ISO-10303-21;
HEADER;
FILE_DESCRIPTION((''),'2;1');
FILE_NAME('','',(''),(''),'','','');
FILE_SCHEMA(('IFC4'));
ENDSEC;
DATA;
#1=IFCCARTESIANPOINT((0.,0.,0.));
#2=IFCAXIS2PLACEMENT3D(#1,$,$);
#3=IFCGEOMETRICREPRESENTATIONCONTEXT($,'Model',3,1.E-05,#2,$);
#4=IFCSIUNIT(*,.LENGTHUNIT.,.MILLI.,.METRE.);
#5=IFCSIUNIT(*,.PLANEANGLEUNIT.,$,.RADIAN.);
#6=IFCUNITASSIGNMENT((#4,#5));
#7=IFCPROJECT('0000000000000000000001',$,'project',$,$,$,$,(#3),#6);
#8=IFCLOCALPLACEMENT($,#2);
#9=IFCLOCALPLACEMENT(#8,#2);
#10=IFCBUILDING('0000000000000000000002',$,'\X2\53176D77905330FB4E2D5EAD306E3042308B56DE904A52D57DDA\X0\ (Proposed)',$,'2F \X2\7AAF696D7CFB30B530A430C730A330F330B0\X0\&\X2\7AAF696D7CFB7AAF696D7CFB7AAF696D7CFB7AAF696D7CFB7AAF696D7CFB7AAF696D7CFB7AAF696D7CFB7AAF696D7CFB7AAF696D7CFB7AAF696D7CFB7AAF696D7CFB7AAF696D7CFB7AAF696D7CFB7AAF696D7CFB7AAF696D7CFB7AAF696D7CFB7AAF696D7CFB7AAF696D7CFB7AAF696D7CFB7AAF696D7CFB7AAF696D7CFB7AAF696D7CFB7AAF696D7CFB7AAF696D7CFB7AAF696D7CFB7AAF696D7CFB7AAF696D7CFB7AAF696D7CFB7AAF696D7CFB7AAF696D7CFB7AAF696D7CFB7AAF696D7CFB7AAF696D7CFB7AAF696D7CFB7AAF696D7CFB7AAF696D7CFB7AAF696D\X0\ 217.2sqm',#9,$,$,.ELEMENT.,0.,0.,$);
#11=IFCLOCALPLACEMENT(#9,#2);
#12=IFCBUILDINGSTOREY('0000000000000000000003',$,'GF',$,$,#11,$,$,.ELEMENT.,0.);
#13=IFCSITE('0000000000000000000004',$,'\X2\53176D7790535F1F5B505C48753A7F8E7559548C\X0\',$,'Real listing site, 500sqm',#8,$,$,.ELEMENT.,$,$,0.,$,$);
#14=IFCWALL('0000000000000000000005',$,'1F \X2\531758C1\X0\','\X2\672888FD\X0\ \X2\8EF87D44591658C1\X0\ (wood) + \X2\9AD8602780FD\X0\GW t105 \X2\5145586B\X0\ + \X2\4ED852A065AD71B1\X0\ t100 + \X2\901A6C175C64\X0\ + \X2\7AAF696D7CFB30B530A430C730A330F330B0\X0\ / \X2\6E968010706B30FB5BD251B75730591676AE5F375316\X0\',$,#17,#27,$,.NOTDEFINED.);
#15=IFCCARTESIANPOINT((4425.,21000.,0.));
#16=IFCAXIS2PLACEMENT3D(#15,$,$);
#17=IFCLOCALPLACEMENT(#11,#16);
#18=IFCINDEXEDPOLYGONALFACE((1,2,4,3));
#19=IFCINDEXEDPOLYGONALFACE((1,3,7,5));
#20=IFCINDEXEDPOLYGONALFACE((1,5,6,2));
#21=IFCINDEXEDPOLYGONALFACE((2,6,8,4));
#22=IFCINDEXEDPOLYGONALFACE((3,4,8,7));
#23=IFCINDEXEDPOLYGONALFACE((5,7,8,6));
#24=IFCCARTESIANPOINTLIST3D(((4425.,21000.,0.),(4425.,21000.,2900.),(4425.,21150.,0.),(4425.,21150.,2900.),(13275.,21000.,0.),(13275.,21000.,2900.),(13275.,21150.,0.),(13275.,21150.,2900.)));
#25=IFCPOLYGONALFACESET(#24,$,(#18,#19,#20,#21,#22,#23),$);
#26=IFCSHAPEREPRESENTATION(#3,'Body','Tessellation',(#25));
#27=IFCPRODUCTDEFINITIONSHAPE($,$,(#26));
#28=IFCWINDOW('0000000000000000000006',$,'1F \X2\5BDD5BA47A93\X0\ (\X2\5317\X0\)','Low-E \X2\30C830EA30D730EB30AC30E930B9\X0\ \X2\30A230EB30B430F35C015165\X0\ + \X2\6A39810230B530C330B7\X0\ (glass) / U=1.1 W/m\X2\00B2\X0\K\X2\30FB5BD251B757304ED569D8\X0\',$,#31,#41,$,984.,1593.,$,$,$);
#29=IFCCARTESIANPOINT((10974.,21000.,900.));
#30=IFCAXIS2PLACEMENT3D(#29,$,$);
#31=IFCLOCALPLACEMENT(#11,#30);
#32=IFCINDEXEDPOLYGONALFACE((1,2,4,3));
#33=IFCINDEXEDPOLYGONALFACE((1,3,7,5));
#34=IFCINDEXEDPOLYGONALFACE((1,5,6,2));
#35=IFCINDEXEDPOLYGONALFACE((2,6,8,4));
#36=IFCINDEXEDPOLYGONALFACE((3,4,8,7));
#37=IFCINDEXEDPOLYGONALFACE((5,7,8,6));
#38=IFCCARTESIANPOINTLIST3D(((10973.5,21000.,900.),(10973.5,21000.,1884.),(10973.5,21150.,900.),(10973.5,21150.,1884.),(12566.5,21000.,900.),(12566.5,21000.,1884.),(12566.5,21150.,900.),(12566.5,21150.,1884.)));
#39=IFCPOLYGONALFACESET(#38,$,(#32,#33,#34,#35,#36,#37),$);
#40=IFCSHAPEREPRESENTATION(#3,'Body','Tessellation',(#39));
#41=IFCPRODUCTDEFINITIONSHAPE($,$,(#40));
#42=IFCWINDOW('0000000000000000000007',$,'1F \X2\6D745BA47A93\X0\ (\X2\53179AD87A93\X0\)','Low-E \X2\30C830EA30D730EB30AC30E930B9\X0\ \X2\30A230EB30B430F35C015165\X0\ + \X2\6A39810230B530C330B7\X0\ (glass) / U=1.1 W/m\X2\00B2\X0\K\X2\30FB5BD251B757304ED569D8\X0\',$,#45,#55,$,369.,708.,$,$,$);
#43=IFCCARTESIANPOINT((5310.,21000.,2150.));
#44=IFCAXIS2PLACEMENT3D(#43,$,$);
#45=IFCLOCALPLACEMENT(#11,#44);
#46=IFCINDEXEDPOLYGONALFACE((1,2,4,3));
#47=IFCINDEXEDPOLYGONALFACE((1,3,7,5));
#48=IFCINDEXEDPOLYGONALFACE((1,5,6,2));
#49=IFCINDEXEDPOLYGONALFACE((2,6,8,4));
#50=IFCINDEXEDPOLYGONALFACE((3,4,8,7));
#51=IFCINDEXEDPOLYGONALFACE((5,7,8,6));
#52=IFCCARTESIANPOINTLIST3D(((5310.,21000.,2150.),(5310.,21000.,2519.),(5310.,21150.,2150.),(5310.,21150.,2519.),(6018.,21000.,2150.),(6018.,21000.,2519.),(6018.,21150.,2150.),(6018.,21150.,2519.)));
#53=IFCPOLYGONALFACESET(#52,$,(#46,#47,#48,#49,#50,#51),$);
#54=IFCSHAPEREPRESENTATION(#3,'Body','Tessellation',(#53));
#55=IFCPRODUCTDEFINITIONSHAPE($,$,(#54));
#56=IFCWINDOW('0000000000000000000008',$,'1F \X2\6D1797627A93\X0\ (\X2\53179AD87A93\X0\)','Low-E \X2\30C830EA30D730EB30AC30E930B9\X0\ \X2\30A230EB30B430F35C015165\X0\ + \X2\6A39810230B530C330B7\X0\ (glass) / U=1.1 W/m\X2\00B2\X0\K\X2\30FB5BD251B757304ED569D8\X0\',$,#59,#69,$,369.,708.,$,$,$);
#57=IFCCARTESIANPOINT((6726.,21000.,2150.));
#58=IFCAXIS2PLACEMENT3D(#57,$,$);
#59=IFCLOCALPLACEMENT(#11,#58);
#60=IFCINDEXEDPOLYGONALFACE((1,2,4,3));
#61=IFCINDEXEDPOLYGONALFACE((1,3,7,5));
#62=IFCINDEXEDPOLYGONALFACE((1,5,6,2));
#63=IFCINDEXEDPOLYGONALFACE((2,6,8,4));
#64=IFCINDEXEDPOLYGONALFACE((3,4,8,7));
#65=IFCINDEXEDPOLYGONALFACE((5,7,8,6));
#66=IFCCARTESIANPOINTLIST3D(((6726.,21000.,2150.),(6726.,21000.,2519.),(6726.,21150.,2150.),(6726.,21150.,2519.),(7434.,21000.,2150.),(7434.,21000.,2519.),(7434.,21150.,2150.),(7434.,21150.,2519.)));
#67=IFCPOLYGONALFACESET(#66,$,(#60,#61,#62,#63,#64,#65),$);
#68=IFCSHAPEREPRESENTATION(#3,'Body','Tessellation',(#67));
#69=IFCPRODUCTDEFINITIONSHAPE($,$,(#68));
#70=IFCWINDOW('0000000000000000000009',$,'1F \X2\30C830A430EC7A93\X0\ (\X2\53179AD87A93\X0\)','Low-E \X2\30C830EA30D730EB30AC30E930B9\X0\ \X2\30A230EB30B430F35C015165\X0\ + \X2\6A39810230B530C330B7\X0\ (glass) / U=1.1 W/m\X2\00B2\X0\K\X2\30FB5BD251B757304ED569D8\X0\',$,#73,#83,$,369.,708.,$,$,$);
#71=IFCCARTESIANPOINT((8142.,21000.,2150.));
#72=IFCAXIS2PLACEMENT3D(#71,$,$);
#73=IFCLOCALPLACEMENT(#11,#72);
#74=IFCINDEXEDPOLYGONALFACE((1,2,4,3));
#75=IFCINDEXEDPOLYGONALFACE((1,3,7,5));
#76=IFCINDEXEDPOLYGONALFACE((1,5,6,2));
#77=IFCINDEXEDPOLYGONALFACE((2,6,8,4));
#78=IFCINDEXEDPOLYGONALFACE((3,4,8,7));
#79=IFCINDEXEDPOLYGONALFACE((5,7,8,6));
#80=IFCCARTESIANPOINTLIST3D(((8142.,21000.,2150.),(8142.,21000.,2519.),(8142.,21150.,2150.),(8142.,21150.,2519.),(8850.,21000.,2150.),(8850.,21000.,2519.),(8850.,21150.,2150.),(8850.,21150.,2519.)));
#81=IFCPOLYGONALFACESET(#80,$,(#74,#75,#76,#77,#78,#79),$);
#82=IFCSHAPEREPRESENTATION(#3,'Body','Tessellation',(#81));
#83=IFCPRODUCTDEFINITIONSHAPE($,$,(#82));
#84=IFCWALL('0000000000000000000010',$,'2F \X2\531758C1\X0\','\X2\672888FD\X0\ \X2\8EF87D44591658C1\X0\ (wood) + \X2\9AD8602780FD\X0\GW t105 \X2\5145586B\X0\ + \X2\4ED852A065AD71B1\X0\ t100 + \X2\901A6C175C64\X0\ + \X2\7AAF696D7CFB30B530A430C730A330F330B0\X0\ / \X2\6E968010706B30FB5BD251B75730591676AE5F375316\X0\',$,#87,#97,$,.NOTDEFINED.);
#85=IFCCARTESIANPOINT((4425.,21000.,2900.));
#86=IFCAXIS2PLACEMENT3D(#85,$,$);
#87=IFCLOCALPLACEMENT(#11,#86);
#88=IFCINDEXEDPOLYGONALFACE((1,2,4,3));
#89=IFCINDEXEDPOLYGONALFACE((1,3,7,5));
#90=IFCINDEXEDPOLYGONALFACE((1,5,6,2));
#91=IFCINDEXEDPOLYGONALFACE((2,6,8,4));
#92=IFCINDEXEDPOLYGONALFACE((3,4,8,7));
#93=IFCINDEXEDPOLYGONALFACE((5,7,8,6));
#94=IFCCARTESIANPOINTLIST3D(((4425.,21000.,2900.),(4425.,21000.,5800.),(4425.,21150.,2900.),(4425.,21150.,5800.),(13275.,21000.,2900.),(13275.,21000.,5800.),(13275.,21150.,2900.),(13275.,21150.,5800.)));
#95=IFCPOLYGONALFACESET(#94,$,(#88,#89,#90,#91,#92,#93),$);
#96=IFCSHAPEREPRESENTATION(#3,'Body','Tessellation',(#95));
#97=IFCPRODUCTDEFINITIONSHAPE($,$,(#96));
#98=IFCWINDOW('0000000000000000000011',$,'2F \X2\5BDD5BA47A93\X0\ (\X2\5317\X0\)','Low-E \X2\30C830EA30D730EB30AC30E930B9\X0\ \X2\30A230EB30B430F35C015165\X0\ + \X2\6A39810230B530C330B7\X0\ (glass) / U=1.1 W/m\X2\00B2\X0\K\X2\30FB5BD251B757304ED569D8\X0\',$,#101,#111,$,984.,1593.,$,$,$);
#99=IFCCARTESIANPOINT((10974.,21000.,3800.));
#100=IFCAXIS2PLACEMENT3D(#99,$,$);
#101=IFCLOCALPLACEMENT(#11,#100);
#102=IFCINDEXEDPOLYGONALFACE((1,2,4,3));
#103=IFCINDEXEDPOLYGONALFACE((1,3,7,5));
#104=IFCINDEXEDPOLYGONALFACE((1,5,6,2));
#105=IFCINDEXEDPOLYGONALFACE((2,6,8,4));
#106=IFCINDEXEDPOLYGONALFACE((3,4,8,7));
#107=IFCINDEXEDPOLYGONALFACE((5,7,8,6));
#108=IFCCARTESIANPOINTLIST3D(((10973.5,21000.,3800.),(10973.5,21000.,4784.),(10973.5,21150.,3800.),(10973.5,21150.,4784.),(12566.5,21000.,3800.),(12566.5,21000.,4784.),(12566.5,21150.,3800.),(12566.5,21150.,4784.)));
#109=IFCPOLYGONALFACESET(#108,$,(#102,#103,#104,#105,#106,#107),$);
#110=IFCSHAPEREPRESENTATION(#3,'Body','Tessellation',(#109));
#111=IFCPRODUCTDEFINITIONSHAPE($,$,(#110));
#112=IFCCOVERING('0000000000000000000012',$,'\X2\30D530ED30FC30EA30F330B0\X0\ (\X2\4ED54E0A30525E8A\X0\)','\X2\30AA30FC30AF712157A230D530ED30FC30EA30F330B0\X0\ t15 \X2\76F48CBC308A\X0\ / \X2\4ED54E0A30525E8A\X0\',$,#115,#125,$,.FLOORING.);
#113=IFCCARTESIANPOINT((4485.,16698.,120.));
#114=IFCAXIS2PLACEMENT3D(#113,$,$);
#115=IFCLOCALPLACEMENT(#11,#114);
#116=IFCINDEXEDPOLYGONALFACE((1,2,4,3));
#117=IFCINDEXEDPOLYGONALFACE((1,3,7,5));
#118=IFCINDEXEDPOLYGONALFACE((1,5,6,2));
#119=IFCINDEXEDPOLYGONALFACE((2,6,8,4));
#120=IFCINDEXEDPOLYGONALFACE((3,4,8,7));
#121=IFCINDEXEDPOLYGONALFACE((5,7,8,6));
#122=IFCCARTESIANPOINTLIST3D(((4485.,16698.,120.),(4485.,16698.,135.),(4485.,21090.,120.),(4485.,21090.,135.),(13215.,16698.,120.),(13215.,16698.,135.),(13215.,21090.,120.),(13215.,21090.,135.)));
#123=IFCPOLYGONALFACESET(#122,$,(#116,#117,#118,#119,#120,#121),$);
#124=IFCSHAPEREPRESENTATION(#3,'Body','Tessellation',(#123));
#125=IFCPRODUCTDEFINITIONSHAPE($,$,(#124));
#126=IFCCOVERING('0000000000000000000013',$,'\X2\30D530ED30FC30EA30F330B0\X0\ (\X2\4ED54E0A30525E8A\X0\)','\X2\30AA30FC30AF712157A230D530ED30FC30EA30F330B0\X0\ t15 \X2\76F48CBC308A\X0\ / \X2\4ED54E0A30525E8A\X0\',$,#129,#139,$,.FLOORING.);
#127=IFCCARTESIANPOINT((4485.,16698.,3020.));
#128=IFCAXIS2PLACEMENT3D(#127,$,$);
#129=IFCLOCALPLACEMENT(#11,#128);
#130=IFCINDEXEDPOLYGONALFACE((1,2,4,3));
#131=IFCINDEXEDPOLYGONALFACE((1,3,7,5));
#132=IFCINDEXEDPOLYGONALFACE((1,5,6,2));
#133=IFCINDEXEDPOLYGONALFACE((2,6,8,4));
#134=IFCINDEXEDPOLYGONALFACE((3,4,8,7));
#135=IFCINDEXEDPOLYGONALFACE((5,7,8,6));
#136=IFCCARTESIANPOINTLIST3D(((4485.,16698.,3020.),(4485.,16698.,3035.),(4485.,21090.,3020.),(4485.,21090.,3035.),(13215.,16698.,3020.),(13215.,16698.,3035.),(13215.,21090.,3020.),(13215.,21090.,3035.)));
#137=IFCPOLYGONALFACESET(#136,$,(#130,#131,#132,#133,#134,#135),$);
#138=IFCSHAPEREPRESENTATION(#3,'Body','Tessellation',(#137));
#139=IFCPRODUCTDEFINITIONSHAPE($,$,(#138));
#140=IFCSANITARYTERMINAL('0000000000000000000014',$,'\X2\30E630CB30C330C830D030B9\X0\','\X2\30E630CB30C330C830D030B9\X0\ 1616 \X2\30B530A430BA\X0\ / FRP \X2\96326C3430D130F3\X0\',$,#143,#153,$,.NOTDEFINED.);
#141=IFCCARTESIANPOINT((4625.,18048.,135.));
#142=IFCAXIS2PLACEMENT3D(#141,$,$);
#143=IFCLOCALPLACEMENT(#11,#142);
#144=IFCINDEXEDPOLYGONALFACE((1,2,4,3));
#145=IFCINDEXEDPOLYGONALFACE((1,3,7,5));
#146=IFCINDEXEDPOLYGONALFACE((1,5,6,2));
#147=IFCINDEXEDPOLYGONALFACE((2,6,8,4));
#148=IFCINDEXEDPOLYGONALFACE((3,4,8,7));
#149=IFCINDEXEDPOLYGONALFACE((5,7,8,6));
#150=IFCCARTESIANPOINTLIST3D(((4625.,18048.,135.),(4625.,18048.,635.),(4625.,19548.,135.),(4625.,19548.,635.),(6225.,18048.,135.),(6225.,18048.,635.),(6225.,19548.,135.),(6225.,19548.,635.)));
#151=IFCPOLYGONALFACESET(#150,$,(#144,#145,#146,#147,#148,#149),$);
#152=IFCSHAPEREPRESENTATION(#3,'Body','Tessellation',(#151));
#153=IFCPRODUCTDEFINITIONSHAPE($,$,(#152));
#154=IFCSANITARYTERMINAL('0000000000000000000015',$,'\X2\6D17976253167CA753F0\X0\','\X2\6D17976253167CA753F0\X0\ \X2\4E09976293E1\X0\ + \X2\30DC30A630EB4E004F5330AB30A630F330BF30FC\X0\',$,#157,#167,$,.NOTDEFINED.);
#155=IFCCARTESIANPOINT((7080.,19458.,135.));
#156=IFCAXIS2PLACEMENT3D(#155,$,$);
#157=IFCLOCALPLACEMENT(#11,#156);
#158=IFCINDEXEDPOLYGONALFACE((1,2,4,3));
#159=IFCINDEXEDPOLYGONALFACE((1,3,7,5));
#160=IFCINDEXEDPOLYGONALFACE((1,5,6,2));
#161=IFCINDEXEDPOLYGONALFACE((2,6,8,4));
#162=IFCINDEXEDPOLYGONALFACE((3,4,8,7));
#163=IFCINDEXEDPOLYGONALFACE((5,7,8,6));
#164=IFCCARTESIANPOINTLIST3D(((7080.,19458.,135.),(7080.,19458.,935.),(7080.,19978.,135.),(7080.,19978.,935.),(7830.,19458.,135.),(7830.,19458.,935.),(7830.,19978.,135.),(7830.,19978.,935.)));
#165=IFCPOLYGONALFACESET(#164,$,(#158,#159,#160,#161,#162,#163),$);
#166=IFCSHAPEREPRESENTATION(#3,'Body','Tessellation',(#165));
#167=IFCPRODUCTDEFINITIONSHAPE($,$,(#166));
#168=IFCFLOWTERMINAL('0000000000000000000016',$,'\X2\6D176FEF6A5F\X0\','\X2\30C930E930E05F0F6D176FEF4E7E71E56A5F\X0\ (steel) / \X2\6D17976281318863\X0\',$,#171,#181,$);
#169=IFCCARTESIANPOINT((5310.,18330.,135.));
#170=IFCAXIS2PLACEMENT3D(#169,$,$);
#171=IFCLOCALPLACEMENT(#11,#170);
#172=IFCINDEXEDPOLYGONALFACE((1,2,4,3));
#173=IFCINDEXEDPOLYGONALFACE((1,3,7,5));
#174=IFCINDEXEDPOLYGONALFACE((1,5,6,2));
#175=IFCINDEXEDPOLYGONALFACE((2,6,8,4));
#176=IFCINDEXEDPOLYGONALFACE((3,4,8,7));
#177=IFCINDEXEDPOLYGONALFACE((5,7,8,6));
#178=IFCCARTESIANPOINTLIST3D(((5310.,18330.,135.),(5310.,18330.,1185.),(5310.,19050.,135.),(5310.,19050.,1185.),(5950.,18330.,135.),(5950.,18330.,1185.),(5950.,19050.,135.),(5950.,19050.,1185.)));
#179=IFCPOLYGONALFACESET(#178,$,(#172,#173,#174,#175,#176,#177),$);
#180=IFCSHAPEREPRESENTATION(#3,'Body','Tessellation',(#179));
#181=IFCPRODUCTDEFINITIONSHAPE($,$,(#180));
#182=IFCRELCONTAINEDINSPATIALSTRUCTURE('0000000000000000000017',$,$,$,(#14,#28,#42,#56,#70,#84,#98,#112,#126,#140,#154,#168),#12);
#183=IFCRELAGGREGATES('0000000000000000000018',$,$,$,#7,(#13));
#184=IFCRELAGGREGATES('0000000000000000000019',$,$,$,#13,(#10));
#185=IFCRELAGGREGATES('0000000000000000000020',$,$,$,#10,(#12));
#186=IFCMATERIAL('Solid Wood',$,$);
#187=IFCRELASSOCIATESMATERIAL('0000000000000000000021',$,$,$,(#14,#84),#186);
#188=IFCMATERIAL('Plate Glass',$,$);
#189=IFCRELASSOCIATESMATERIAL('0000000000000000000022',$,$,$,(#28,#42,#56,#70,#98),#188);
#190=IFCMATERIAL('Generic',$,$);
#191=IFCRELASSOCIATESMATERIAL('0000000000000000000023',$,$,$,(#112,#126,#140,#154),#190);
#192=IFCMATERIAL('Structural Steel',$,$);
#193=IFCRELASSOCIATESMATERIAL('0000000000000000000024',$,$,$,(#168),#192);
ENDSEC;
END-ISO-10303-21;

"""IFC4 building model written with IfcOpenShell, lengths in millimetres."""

from ifc_helpers import new_model, si_unit, frame, frame_2d, origin, place, context, project, spatial, rectangle, extrude, material, element, fill, save


model = new_model("IFC4")

# Units and contexts
model_context = context("Model", 3, precision=1e-05, world=origin())
ifc_project = project(units=[si_unit("LENGTHUNIT", "METRE", prefix="MILLI"), si_unit("PLANEANGLEUNIT", "RADIAN")], contexts=[model_context])

# Site, building, storey
site_placement = place(None, origin())
site = spatial("IfcSite", under=ifc_project, at=site_placement, Name="北海道弟子屈町美留和", ObjectType="Real listing site, 500sqm", CompositionType="ELEMENT", RefElevation=0.0)
building_placement = place(site_placement, origin())
building = spatial("IfcBuilding", under=site, at=building_placement, Name="北海道・中庭のある回遊動線 (Proposed)", ObjectType="2F 窯業系サイディング&窯業系窯業系窯業系窯業系窯業系窯業系窯業系窯業系窯業系窯業系窯業系窯業系窯業系窯業系窯業系窯業系窯業系窯業系窯業系窯業系窯業系窯業系窯業系窯業系窯業系窯業系窯業系窯業系窯業系窯業系窯業系窯業系窯業系窯業系窯業系窯業系窯業 217.2sqm", CompositionType="ELEMENT", ElevationOfRefHeight=0.0, ElevationOfTerrain=0.0)
storey_placement = place(building_placement, origin())
storey = spatial("IfcBuildingStorey", under=building, at=storey_placement, Name="GF", CompositionType="ELEMENT", Elevation=0.0)

# Shared definitions
ifc_material_1 = material(Name="Solid Wood")

# Wall, openings, windows
wall_1_placement = place(storey_placement, frame((4425.0, 21000.0, 0.0)))
wall_1 = element("IfcWall", 1, at=wall_1_placement, inside=storey, material=ifc_material_1, Name="1F 北壁", Description="木製 軸組外壁 (wood) + 高性能GW t105 充填 + 付加断熱 t100 + 通気層 + 窯業系サイディング / 準耐火・寒冷地外皮強化", PredefinedType="NOTDEFINED", context=model_context, shape_type="SweptSolid", body=[
    extrude(rectangle(XDim=8850.0, YDim=150.0, at=frame_2d((4425.0, 75.0))), frame((4425.0, 21000.0, 0.0)), (0.0, 0.0, 1.0), 2900.0),
])
opening_1_placement = place(storey_placement, frame((10974.0, 21000.0, 900.0)))
opening_1 = element("IfcOpeningElement", 2, at=opening_1_placement, cuts=wall_1, PredefinedType="NOTDEFINED", context=model_context, shape_type="SweptSolid", body=[
    extrude(rectangle(XDim=1593.0, YDim=150.0, at=frame_2d((796.0, 75.0))), frame((10974.0, 21000.0, 900.0)), (0.0, 0.0, 1.0), 984.0),
])
opening_2_placement = place(storey_placement, frame((5310.0, 21000.0, 2150.0)))
opening_2 = element("IfcOpeningElement", 3, at=opening_2_placement, cuts=wall_1, PredefinedType="NOTDEFINED", context=model_context, shape_type="SweptSolid", body=[
    extrude(rectangle(XDim=708.0, YDim=150.0, at=frame_2d((354.0, 75.0))), frame((5310.0, 21000.0, 2150.0)), (0.0, 0.0, 1.0), 369.0),
])
opening_3_placement = place(storey_placement, frame((6726.0, 21000.0, 2150.0)))
opening_3 = element("IfcOpeningElement", 4, at=opening_3_placement, cuts=wall_1, PredefinedType="NOTDEFINED", context=model_context, shape_type="SweptSolid", body=[
    extrude(rectangle(XDim=708.0, YDim=150.0, at=frame_2d((354.0, 75.0))), frame((6726.0, 21000.0, 2150.0)), (0.0, 0.0, 1.0), 369.0),
])
opening_4_placement = place(storey_placement, frame((8142.0, 21000.0, 2150.0)))
opening_4 = element("IfcOpeningElement", 5, at=opening_4_placement, cuts=wall_1, PredefinedType="NOTDEFINED", context=model_context, shape_type="SweptSolid", body=[
    extrude(rectangle(XDim=708.0, YDim=150.0, at=frame_2d((354.0, 75.0))), frame((8142.0, 21000.0, 2150.0)), (0.0, 0.0, 1.0), 369.0),
])
ifc_material_2 = material(Name="Plate Glass")
window_1_placement = place(storey_placement, frame((10974.0, 21000.0, 900.0)))
window_1 = element("IfcWindow", 6, at=window_1_placement, inside=storey, material=ifc_material_2, Name="1F 寝室窓 (北)", Description="Low-E トリプルガラス アルゴン封入 + 樹脂サッシ (glass) / U=1.1 W/m²K・寒冷地仕様", OverallHeight=984.0, OverallWidth=1593.0, context=model_context, shape_type="SweptSolid", body=[
    extrude(rectangle(XDim=1593.0, YDim=150.0, at=frame_2d((796.0, 75.0))), frame((10974.0, 21000.0, 900.0)), (0.0, 0.0, 1.0), 984.0),
])
fill(opening_1, window_1)
window_2_placement = place(storey_placement, frame((5310.0, 21000.0, 2150.0)))
window_2 = element("IfcWindow", 7, at=window_2_placement, inside=storey, material=ifc_material_2, Name="1F 浴室窓 (北高窓)", Description="Low-E トリプルガラス アルゴン封入 + 樹脂サッシ (glass) / U=1.1 W/m²K・寒冷地仕様", OverallHeight=369.0, OverallWidth=708.0, context=model_context, shape_type="SweptSolid", body=[
    extrude(rectangle(XDim=708.0, YDim=150.0, at=frame_2d((354.0, 75.0))), frame((5310.0, 21000.0, 2150.0)), (0.0, 0.0, 1.0), 369.0),
])
fill(opening_2, window_2)
window_3_placement = place(storey_placement, frame((6726.0, 21000.0, 2150.0)))
window_3 = element("IfcWindow", 8, at=window_3_placement, inside=storey, material=ifc_material_2, Name="1F 洗面窓 (北高窓)", Description="Low-E トリプルガラス アルゴン封入 + 樹脂サッシ (glass) / U=1.1 W/m²K・寒冷地仕様", OverallHeight=369.0, OverallWidth=708.0, context=model_context, shape_type="SweptSolid", body=[
    extrude(rectangle(XDim=708.0, YDim=150.0, at=frame_2d((354.0, 75.0))), frame((6726.0, 21000.0, 2150.0)), (0.0, 0.0, 1.0), 369.0),
])
fill(opening_3, window_3)
window_4_placement = place(storey_placement, frame((8142.0, 21000.0, 2150.0)))
window_4 = element("IfcWindow", 9, at=window_4_placement, inside=storey, material=ifc_material_2, Name="1F トイレ窓 (北高窓)", Description="Low-E トリプルガラス アルゴン封入 + 樹脂サッシ (glass) / U=1.1 W/m²K・寒冷地仕様", OverallHeight=369.0, OverallWidth=708.0, context=model_context, shape_type="SweptSolid", body=[
    extrude(rectangle(XDim=708.0, YDim=150.0, at=frame_2d((354.0, 75.0))), frame((8142.0, 21000.0, 2150.0)), (0.0, 0.0, 1.0), 369.0),
])
fill(opening_4, window_4)

# Wall, opening, window
wall_2_placement = place(storey_placement, frame((4425.0, 21000.0, 2900.0)))
wall_2 = element("IfcWall", 10, at=wall_2_placement, inside=storey, material=ifc_material_1, Name="2F 北壁", Description="木製 軸組外壁 (wood) + 高性能GW t105 充填 + 付加断熱 t100 + 通気層 + 窯業系サイディング / 準耐火・寒冷地外皮強化", PredefinedType="NOTDEFINED", context=model_context, shape_type="SweptSolid", body=[
    extrude(rectangle(XDim=8850.0, YDim=150.0, at=frame_2d((4425.0, 75.0))), frame((4425.0, 21000.0, 2900.0)), (0.0, 0.0, 1.0), 2900.0),
])
opening_5_placement = place(storey_placement, frame((10974.0, 21000.0, 3800.0)))
opening_5 = element("IfcOpeningElement", 11, at=opening_5_placement, cuts=wall_2, PredefinedType="NOTDEFINED", context=model_context, shape_type="SweptSolid", body=[
    extrude(rectangle(XDim=1593.0, YDim=150.0, at=frame_2d((796.0, 75.0))), frame((10974.0, 21000.0, 3800.0)), (0.0, 0.0, 1.0), 984.0),
])
window_5_placement = place(storey_placement, frame((10974.0, 21000.0, 3800.0)))
window_5 = element("IfcWindow", 12, at=window_5_placement, inside=storey, material=ifc_material_2, Name="2F 寝室窓 (北)", Description="Low-E トリプルガラス アルゴン封入 + 樹脂サッシ (glass) / U=1.1 W/m²K・寒冷地仕様", OverallHeight=984.0, OverallWidth=1593.0, context=model_context, shape_type="SweptSolid", body=[
    extrude(rectangle(XDim=1593.0, YDim=150.0, at=frame_2d((796.0, 75.0))), frame((10974.0, 21000.0, 3800.0)), (0.0, 0.0, 1.0), 984.0),
])
fill(opening_5, window_5)

# Coverings
ifc_material_3 = material(Name="Generic")
covering_1_placement = place(storey_placement, frame((4485.0, 16698.0, 120.0)))
element("IfcCovering", 13, at=covering_1_placement, inside=storey, material=ifc_material_3, Name="フローリング (仕上げ床)", Description="オーク無垢フローリング t15 直貼り / 仕上げ床", PredefinedType="FLOORING", context=model_context, shape_type="SweptSolid", body=[
    extrude(rectangle(XDim=8730.0, YDim=4392.0, at=frame_2d((4365.0, 2196.0))), frame((4485.0, 16698.0, 120.0)), (0.0, 0.0, 1.0), 15.0),
])
covering_2_placement = place(storey_placement, frame((4485.0, 16698.0, 3020.0)))
element("IfcCovering", 14, at=covering_2_placement, inside=storey, material=ifc_material_3, Name="フローリング (仕上げ床)", Description="オーク無垢フローリング t15 直貼り / 仕上げ床", PredefinedType="FLOORING", context=model_context, shape_type="SweptSolid", body=[
    extrude(rectangle(XDim=8730.0, YDim=4392.0, at=frame_2d((4365.0, 2196.0))), frame((4485.0, 16698.0, 3020.0)), (0.0, 0.0, 1.0), 15.0),
])

# Sanitary terminals
sanitary_terminal_1_placement = place(storey_placement, frame((4625.0, 18048.0, 135.0)))
element("IfcSanitaryTerminal", 15, at=sanitary_terminal_1_placement, inside=storey, material=ifc_material_3, Name="ユニットバス", Description="ユニットバス 1616 サイズ / FRP 防水パン", PredefinedType="NOTDEFINED", context=model_context, shape_type="SweptSolid", body=[
    extrude(rectangle(XDim=1600.0, YDim=1500.0, at=frame_2d((800.0, 750.0))), frame((4625.0, 18048.0, 135.0)), (0.0, 0.0, 1.0), 500.0),
])
sanitary_terminal_2_placement = place(storey_placement, frame((7080.0, 19458.0, 135.0)))
element("IfcSanitaryTerminal", 16, at=sanitary_terminal_2_placement, inside=storey, material=ifc_material_3, Name="洗面化粧台", Description="洗面化粧台 三面鏡 + ボウル一体カウンター", PredefinedType="NOTDEFINED", context=model_context, shape_type="SweptSolid", body=[
    extrude(rectangle(XDim=750.0, YDim=520.0, at=frame_2d((375.0, 260.0))), frame((7080.0, 19458.0, 135.0)), (0.0, 0.0, 1.0), 800.0),
])

# Flow terminal
ifc_material_4 = material(Name="Structural Steel")
flow_terminal_placement = place(storey_placement, frame((5310.0, 18330.0, 135.0)))
element("IfcFlowTerminal", 17, at=flow_terminal_placement, inside=storey, material=ifc_material_4, Name="洗濯機", Description="ドラム式洗濯乾燥機 (steel) / 洗面脱衣", context=model_context, shape_type="SweptSolid", body=[
    extrude(rectangle(XDim=640.0, YDim=720.0, at=frame_2d((320.0, 360.0))), frame((5310.0, 18330.0, 135.0)), (0.0, 0.0, 1.0), 1050.0),
])

save(model, "model.ifc")
